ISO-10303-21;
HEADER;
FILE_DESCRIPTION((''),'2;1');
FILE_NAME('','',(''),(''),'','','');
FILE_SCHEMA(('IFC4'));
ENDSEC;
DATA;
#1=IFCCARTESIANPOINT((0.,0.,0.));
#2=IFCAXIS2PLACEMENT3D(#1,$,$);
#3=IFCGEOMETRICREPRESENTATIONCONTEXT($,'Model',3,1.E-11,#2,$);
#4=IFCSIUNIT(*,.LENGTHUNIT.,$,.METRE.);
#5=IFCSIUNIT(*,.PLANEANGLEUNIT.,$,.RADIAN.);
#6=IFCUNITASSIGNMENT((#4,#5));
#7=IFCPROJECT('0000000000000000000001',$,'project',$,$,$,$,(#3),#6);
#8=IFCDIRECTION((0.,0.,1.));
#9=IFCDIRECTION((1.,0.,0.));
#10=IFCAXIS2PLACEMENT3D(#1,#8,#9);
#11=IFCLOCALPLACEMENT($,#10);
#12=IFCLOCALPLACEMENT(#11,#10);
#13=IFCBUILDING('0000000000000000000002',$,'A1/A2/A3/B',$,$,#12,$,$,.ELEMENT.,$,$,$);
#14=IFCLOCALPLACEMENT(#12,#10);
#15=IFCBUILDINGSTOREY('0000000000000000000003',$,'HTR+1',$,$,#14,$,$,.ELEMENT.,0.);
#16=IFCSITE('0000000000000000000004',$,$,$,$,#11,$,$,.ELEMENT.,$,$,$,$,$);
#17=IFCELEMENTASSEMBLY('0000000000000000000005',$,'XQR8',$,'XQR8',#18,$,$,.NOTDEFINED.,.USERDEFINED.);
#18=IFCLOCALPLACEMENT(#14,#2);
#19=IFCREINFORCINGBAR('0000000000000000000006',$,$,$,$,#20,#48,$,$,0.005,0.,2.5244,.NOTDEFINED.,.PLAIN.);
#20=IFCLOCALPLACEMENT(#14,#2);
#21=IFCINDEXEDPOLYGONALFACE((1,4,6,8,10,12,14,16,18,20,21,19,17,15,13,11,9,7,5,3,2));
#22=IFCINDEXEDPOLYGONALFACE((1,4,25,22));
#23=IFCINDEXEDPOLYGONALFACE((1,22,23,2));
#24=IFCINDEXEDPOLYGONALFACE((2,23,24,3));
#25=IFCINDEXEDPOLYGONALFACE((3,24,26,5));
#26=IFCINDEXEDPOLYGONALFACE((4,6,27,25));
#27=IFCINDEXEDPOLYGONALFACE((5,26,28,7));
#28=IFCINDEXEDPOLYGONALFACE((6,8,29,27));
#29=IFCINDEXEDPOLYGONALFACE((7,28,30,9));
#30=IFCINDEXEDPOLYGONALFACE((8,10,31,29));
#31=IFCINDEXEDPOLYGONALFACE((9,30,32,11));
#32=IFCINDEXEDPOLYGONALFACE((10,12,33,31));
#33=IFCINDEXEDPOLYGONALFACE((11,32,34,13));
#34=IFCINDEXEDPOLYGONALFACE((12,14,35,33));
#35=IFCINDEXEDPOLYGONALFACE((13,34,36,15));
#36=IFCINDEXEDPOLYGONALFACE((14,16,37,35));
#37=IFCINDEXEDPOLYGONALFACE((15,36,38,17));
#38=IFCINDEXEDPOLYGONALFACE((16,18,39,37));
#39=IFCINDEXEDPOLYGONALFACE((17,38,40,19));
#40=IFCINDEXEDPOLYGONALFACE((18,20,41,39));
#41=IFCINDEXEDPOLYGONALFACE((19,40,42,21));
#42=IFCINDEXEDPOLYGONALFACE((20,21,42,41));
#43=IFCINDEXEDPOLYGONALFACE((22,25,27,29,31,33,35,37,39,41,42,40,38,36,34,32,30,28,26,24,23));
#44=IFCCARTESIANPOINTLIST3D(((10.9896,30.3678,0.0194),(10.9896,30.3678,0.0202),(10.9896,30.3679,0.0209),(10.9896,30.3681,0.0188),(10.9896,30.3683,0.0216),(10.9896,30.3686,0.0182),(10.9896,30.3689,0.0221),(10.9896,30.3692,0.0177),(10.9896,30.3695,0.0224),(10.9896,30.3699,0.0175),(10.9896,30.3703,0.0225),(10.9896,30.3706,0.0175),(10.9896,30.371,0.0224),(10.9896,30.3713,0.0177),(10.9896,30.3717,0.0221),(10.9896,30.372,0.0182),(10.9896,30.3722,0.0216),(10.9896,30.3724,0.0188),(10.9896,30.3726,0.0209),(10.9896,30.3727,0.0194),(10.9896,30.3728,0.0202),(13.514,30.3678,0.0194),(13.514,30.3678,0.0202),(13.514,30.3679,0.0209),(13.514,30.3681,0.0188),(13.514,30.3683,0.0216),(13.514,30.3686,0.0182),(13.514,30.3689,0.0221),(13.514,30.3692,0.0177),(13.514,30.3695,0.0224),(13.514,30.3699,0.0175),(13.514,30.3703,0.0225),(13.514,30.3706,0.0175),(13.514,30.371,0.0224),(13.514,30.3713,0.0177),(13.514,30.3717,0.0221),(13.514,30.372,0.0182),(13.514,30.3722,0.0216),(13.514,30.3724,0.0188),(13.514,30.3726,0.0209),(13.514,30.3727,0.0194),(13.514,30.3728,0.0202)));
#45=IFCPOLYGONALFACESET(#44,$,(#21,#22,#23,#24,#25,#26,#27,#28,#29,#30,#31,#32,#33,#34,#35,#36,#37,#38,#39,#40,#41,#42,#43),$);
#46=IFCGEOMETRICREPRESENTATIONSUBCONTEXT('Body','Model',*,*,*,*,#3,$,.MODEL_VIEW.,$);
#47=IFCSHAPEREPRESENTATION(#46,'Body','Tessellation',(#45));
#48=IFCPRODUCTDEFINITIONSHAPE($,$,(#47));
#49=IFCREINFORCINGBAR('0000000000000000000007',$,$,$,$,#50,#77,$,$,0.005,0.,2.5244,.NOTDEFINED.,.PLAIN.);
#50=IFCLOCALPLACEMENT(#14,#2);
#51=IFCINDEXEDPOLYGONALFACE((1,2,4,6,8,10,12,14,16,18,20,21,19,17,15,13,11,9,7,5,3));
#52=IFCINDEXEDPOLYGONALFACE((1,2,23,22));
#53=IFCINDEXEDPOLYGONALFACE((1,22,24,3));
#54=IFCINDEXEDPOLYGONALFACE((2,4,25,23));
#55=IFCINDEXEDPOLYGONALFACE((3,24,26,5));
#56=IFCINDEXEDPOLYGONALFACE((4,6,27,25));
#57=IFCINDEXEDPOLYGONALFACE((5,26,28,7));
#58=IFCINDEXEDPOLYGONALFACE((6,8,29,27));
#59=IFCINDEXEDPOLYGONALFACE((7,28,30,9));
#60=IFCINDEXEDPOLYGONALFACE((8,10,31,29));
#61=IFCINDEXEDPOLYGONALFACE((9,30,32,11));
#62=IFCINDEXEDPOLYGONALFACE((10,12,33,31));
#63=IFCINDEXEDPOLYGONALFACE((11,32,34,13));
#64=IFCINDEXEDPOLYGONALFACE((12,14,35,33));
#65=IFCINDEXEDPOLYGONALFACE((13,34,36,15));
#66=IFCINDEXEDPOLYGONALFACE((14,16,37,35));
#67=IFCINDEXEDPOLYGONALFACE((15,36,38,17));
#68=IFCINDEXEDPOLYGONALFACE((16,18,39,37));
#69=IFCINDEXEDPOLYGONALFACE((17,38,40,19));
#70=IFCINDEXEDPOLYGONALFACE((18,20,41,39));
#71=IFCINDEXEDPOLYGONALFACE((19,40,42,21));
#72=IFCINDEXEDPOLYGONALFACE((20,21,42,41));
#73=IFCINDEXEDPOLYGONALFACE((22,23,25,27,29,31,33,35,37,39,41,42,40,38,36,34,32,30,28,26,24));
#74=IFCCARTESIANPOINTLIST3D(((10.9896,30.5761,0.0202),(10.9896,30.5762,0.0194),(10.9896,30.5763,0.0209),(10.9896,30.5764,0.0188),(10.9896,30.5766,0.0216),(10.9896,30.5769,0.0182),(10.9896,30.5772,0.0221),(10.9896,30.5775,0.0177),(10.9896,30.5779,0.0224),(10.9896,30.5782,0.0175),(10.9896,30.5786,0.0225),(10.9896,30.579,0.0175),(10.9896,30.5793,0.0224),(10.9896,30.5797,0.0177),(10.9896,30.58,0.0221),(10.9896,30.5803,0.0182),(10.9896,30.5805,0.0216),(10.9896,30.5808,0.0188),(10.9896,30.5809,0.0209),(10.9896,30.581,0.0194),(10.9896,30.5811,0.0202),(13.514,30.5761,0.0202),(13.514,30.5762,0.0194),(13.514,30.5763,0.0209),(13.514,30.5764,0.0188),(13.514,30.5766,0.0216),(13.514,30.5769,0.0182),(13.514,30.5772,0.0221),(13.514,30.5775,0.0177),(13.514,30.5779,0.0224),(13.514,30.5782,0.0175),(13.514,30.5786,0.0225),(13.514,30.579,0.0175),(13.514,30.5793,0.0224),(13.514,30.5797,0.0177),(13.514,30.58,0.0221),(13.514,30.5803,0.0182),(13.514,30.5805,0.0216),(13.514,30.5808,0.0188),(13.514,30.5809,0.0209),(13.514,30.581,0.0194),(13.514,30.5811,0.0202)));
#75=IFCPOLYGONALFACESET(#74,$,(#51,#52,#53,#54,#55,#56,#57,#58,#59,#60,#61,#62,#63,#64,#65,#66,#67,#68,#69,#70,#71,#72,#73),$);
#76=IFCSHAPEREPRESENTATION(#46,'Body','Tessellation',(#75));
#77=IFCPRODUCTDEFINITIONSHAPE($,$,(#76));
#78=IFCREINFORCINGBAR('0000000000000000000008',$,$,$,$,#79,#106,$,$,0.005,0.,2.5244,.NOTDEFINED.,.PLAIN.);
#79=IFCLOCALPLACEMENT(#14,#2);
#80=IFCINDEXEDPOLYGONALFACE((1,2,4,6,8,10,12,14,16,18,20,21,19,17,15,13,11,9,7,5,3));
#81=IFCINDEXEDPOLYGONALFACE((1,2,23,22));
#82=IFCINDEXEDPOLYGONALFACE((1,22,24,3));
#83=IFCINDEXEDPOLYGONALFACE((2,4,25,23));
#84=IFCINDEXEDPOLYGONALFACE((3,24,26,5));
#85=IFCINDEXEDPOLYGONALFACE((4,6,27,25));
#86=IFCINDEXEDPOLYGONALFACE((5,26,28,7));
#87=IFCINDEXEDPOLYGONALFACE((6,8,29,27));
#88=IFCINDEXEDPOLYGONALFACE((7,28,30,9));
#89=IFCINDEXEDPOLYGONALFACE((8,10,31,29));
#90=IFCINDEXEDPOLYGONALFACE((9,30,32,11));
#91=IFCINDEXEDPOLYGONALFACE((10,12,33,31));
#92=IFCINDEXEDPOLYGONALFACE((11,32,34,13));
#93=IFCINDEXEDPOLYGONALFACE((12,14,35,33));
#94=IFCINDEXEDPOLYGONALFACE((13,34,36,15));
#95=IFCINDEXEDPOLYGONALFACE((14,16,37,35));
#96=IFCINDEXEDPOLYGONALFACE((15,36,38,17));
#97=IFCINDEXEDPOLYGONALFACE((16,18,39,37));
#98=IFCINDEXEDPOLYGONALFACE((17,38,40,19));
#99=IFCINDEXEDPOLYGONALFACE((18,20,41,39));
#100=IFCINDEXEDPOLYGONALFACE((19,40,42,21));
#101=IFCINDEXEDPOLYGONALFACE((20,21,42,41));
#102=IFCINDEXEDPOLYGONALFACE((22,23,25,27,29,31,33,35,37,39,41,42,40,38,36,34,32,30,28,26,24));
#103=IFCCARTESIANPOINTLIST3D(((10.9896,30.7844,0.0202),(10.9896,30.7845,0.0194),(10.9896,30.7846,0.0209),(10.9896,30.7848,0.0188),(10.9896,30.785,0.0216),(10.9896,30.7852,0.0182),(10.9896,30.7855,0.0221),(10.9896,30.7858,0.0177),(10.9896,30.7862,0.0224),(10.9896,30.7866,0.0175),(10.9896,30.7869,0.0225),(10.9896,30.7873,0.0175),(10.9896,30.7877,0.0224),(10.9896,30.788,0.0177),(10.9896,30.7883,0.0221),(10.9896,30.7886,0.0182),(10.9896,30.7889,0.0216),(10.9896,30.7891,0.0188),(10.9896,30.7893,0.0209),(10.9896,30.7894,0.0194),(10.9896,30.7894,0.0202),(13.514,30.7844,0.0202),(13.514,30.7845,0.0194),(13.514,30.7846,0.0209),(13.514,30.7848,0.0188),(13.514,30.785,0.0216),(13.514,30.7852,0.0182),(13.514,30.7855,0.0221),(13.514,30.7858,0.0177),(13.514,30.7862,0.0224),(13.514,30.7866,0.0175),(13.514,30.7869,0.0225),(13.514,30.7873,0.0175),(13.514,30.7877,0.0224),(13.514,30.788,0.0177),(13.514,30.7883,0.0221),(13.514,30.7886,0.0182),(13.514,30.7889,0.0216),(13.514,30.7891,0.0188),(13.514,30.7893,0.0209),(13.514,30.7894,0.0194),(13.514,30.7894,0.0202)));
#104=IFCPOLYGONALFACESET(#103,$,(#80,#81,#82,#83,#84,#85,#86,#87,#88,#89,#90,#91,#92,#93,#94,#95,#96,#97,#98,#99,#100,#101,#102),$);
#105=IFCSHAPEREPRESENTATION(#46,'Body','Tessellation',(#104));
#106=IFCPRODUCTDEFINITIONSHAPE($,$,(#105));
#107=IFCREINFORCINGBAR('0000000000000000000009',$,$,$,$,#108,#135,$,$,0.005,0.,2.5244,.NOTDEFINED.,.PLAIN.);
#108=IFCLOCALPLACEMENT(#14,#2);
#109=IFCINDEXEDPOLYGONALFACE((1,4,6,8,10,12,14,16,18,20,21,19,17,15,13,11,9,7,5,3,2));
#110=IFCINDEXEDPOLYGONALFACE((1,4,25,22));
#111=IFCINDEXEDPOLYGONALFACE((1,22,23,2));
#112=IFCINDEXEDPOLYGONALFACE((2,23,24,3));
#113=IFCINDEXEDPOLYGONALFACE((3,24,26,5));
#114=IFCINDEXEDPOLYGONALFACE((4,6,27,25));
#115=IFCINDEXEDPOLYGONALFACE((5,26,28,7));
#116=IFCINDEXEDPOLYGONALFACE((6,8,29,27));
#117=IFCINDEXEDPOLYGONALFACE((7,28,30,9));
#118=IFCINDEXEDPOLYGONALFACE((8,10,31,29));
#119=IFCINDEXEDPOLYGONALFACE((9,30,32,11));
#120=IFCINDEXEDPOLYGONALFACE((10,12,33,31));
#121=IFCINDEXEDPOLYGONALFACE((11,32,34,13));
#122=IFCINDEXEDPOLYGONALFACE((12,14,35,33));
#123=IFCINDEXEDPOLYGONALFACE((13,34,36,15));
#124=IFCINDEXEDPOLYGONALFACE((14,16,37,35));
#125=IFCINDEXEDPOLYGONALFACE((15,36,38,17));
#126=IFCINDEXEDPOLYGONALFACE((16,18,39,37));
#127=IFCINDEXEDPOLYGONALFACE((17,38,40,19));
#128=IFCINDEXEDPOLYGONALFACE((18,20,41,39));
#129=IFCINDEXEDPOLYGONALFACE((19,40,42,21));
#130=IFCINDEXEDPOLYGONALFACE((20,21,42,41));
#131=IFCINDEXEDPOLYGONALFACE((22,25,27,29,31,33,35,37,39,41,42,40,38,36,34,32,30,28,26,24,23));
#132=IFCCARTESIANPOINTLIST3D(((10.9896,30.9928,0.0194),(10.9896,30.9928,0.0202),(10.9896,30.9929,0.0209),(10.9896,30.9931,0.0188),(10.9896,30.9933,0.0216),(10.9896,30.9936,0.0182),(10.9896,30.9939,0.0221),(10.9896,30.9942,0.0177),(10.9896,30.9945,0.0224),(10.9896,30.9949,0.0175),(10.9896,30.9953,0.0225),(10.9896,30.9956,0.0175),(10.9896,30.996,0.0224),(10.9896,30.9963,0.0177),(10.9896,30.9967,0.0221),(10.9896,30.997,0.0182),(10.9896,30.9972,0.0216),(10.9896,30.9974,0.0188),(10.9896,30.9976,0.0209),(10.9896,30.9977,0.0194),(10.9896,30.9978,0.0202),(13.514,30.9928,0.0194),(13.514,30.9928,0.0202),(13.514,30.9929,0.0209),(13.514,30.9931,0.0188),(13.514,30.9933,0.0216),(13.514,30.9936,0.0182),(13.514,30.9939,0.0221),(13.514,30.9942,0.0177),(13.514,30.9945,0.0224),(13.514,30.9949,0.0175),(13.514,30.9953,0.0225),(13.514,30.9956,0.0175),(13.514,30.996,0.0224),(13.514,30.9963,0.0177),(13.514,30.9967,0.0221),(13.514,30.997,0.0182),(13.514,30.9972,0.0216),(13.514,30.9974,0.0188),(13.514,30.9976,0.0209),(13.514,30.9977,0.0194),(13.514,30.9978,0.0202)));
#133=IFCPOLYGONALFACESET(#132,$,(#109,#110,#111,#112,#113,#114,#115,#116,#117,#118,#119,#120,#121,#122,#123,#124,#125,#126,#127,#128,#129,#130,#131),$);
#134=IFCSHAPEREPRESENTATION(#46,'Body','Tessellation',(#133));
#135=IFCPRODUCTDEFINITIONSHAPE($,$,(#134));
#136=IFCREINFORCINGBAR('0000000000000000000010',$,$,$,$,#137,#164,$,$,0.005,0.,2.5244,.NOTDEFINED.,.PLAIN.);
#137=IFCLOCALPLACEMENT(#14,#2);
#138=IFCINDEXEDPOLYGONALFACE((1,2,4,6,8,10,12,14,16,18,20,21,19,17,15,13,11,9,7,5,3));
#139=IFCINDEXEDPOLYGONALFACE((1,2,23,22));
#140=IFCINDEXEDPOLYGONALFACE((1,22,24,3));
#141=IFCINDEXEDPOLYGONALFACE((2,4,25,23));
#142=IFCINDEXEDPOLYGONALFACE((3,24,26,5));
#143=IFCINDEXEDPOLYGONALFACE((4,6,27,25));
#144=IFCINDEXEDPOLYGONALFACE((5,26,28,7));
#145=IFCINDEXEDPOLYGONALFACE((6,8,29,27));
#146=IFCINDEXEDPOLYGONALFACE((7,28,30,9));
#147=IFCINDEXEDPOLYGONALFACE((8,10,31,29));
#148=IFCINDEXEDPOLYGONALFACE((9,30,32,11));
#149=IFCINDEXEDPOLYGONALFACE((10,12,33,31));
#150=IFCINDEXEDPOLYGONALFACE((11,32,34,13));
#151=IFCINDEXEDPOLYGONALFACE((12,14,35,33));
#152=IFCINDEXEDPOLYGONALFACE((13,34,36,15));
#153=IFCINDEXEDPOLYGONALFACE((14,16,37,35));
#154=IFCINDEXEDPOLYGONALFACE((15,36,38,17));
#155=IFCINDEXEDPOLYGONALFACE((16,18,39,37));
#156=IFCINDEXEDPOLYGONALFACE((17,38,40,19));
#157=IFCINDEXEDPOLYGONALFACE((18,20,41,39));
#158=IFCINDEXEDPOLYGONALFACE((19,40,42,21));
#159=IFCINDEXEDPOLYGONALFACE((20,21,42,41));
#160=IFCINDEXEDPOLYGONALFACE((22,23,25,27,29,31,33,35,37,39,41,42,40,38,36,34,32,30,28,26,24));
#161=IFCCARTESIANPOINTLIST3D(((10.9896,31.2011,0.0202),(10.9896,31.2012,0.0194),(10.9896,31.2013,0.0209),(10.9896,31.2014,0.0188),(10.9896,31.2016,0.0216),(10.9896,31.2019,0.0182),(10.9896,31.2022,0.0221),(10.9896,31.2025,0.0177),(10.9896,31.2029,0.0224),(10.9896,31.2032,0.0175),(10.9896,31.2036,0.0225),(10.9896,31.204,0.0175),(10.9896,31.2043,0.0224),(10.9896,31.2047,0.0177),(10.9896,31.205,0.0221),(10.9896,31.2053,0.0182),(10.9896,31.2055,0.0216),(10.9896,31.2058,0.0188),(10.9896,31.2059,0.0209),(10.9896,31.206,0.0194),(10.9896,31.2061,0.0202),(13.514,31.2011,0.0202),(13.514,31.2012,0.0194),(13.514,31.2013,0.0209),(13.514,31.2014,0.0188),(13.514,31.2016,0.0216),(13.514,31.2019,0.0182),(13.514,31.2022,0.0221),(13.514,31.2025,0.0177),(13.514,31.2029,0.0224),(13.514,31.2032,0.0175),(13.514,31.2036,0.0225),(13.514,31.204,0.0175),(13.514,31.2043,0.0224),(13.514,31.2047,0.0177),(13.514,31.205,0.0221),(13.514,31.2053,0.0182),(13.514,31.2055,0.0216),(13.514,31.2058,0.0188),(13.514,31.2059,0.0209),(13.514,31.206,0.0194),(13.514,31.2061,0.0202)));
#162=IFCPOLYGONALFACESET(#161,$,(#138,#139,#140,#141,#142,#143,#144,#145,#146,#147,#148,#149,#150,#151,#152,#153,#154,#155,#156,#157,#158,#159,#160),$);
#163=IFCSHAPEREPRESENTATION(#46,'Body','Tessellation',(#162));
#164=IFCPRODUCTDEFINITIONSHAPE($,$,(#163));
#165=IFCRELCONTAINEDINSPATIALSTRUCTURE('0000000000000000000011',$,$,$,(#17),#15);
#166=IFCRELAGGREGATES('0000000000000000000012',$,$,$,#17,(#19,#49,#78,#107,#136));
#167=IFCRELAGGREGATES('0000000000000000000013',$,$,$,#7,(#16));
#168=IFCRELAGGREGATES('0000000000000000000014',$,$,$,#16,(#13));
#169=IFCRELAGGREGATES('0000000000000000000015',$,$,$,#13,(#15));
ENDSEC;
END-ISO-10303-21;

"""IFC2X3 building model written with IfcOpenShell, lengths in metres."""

from ifc_helpers import new_model, entity, si_unit, origin, origin_with_axes, place, context, subcontext, project, spatial, shape, element, aggregate, save


model = new_model("IFC2X3")

# Units and contexts
model_context = context("Model", 3, precision=1e-11, world=origin())
body_context = subcontext(model_context, "Body", "Model", "MODEL_VIEW")
ifc_project = project(units=[si_unit("LENGTHUNIT", "METRE"), si_unit("PLANEANGLEUNIT", "RADIAN")], contexts=[model_context])

# Site, building, storey
site_placement = place(None, origin_with_axes())
site = spatial("IfcSite", under=ifc_project, at=site_placement, CompositionType="ELEMENT")
building_placement = place(site_placement, origin_with_axes())
building = spatial("IfcBuilding", under=site, at=building_placement, Name="A1/A2/A3/B", CompositionType="ELEMENT")
storey_placement = place(building_placement, origin_with_axes())
storey = spatial("IfcBuildingStorey", under=building, at=storey_placement, Name="HTR+1", CompositionType="ELEMENT", Elevation=0.0)

# Element assembly, reinforcing bars
assembly_1_placement = place(storey_placement, origin_with_axes())
assembly_1 = element("IfcElementAssembly", 1, at=assembly_1_placement, inside=storey, Name="XQR8", ObjectType="XQR8", AssemblyPlace="NOTDEFINED", PredefinedType="USERDEFINED")
reinforcing_bar_1_placement = place(assembly_1_placement, origin_with_axes())
reinforcing_bar_1 = element("IfcReinforcingBar", 2, at=reinforcing_bar_1_placement, BarLength=2.5244, BarRole="NOTDEFINED", BarSurface="PLAIN", CrossSectionArea=0.0, NominalDiameter=0.005, shapes=[
    shape(body_context, "Body", "AdvancedSweptSolid", [entity("IfcSweptDiskSolid", entity("IfcPolyline", [entity("IfcCartesianPoint", [10.9896, 30.3703, 0.02]), entity("IfcCartesianPoint", [13.514, 30.3703, 0.02])]), 0.0025, None, 0.0, 2.5244)]),
    shape(body_context, "Body", "AdvancedSweptSolid", [entity("IfcSweptDiskSolid", entity("IfcPolyline", [entity("IfcCartesianPoint", [10.9896, 30.3703, 0.02]), entity("IfcCartesianPoint", [13.514, 30.3703, 0.02])]), 0.0025, None, 0.0, 2.5244)]),
])
reinforcing_bar_2_placement = place(assembly_1_placement, origin_with_axes())
reinforcing_bar_2 = element("IfcReinforcingBar", 3, at=reinforcing_bar_2_placement, BarLength=2.5244, BarRole="NOTDEFINED", BarSurface="PLAIN", CrossSectionArea=0.0, NominalDiameter=0.005, shapes=[
    shape(body_context, "Body", "AdvancedSweptSolid", [entity("IfcSweptDiskSolid", entity("IfcPolyline", [entity("IfcCartesianPoint", [10.9896, 30.5786, 0.02]), entity("IfcCartesianPoint", [13.514, 30.5786, 0.02])]), 0.0025, None, 0.0, 2.5244)]),
    shape(body_context, "Body", "AdvancedSweptSolid", [entity("IfcSweptDiskSolid", entity("IfcPolyline", [entity("IfcCartesianPoint", [10.9896, 30.5786, 0.02]), entity("IfcCartesianPoint", [13.514, 30.5786, 0.02])]), 0.0025, None, 0.0, 2.5244)]),
])
reinforcing_bar_3_placement = place(assembly_1_placement, origin_with_axes())
reinforcing_bar_3 = element("IfcReinforcingBar", 4, at=reinforcing_bar_3_placement, BarLength=2.5244, BarRole="NOTDEFINED", BarSurface="PLAIN", CrossSectionArea=0.0, NominalDiameter=0.005, shapes=[
    shape(body_context, "Body", "AdvancedSweptSolid", [entity("IfcSweptDiskSolid", entity("IfcPolyline", [entity("IfcCartesianPoint", [10.9896, 30.7869, 0.02]), entity("IfcCartesianPoint", [13.514, 30.7869, 0.02])]), 0.0025, None, 0.0, 2.5244)]),
    shape(body_context, "Body", "AdvancedSweptSolid", [entity("IfcSweptDiskSolid", entity("IfcPolyline", [entity("IfcCartesianPoint", [10.9896, 30.7869, 0.02]), entity("IfcCartesianPoint", [13.514, 30.7869, 0.02])]), 0.0025, None, 0.0, 2.5244)]),
])
reinforcing_bar_4_placement = place(assembly_1_placement, origin_with_axes())
reinforcing_bar_4 = element("IfcReinforcingBar", 5, at=reinforcing_bar_4_placement, BarLength=2.5244, BarRole="NOTDEFINED", BarSurface="PLAIN", CrossSectionArea=0.0, NominalDiameter=0.005, shapes=[
    shape(body_context, "Body", "AdvancedSweptSolid", [entity("IfcSweptDiskSolid", entity("IfcPolyline", [entity("IfcCartesianPoint", [10.9896, 30.9953, 0.02]), entity("IfcCartesianPoint", [13.514, 30.9953, 0.02])]), 0.0025, None, 0.0, 2.5244)]),
    shape(body_context, "Body", "AdvancedSweptSolid", [entity("IfcSweptDiskSolid", entity("IfcPolyline", [entity("IfcCartesianPoint", [10.9896, 30.9953, 0.02]), entity("IfcCartesianPoint", [13.514, 30.9953, 0.02])]), 0.0025, None, 0.0, 2.5244)]),
])
reinforcing_bar_5_placement = place(assembly_1_placement, origin_with_axes())
reinforcing_bar_5 = element("IfcReinforcingBar", 6, at=reinforcing_bar_5_placement, BarLength=2.5244, BarRole="NOTDEFINED", BarSurface="PLAIN", CrossSectionArea=0.0, NominalDiameter=0.005, shapes=[
    shape(body_context, "Body", "AdvancedSweptSolid", [entity("IfcSweptDiskSolid", entity("IfcPolyline", [entity("IfcCartesianPoint", [10.9896, 31.2036, 0.02]), entity("IfcCartesianPoint", [13.514, 31.2036, 0.02])]), 0.0025, None, 0.0, 2.5244)]),
    shape(body_context, "Body", "AdvancedSweptSolid", [entity("IfcSweptDiskSolid", entity("IfcPolyline", [entity("IfcCartesianPoint", [10.9896, 31.2036, 0.02]), entity("IfcCartesianPoint", [13.514, 31.2036, 0.02])]), 0.0025, None, 0.0, 2.5244)]),
])
aggregate(assembly_1, [reinforcing_bar_1, reinforcing_bar_2, reinforcing_bar_3, reinforcing_bar_4, reinforcing_bar_5])

save(model, "model.ifc")
